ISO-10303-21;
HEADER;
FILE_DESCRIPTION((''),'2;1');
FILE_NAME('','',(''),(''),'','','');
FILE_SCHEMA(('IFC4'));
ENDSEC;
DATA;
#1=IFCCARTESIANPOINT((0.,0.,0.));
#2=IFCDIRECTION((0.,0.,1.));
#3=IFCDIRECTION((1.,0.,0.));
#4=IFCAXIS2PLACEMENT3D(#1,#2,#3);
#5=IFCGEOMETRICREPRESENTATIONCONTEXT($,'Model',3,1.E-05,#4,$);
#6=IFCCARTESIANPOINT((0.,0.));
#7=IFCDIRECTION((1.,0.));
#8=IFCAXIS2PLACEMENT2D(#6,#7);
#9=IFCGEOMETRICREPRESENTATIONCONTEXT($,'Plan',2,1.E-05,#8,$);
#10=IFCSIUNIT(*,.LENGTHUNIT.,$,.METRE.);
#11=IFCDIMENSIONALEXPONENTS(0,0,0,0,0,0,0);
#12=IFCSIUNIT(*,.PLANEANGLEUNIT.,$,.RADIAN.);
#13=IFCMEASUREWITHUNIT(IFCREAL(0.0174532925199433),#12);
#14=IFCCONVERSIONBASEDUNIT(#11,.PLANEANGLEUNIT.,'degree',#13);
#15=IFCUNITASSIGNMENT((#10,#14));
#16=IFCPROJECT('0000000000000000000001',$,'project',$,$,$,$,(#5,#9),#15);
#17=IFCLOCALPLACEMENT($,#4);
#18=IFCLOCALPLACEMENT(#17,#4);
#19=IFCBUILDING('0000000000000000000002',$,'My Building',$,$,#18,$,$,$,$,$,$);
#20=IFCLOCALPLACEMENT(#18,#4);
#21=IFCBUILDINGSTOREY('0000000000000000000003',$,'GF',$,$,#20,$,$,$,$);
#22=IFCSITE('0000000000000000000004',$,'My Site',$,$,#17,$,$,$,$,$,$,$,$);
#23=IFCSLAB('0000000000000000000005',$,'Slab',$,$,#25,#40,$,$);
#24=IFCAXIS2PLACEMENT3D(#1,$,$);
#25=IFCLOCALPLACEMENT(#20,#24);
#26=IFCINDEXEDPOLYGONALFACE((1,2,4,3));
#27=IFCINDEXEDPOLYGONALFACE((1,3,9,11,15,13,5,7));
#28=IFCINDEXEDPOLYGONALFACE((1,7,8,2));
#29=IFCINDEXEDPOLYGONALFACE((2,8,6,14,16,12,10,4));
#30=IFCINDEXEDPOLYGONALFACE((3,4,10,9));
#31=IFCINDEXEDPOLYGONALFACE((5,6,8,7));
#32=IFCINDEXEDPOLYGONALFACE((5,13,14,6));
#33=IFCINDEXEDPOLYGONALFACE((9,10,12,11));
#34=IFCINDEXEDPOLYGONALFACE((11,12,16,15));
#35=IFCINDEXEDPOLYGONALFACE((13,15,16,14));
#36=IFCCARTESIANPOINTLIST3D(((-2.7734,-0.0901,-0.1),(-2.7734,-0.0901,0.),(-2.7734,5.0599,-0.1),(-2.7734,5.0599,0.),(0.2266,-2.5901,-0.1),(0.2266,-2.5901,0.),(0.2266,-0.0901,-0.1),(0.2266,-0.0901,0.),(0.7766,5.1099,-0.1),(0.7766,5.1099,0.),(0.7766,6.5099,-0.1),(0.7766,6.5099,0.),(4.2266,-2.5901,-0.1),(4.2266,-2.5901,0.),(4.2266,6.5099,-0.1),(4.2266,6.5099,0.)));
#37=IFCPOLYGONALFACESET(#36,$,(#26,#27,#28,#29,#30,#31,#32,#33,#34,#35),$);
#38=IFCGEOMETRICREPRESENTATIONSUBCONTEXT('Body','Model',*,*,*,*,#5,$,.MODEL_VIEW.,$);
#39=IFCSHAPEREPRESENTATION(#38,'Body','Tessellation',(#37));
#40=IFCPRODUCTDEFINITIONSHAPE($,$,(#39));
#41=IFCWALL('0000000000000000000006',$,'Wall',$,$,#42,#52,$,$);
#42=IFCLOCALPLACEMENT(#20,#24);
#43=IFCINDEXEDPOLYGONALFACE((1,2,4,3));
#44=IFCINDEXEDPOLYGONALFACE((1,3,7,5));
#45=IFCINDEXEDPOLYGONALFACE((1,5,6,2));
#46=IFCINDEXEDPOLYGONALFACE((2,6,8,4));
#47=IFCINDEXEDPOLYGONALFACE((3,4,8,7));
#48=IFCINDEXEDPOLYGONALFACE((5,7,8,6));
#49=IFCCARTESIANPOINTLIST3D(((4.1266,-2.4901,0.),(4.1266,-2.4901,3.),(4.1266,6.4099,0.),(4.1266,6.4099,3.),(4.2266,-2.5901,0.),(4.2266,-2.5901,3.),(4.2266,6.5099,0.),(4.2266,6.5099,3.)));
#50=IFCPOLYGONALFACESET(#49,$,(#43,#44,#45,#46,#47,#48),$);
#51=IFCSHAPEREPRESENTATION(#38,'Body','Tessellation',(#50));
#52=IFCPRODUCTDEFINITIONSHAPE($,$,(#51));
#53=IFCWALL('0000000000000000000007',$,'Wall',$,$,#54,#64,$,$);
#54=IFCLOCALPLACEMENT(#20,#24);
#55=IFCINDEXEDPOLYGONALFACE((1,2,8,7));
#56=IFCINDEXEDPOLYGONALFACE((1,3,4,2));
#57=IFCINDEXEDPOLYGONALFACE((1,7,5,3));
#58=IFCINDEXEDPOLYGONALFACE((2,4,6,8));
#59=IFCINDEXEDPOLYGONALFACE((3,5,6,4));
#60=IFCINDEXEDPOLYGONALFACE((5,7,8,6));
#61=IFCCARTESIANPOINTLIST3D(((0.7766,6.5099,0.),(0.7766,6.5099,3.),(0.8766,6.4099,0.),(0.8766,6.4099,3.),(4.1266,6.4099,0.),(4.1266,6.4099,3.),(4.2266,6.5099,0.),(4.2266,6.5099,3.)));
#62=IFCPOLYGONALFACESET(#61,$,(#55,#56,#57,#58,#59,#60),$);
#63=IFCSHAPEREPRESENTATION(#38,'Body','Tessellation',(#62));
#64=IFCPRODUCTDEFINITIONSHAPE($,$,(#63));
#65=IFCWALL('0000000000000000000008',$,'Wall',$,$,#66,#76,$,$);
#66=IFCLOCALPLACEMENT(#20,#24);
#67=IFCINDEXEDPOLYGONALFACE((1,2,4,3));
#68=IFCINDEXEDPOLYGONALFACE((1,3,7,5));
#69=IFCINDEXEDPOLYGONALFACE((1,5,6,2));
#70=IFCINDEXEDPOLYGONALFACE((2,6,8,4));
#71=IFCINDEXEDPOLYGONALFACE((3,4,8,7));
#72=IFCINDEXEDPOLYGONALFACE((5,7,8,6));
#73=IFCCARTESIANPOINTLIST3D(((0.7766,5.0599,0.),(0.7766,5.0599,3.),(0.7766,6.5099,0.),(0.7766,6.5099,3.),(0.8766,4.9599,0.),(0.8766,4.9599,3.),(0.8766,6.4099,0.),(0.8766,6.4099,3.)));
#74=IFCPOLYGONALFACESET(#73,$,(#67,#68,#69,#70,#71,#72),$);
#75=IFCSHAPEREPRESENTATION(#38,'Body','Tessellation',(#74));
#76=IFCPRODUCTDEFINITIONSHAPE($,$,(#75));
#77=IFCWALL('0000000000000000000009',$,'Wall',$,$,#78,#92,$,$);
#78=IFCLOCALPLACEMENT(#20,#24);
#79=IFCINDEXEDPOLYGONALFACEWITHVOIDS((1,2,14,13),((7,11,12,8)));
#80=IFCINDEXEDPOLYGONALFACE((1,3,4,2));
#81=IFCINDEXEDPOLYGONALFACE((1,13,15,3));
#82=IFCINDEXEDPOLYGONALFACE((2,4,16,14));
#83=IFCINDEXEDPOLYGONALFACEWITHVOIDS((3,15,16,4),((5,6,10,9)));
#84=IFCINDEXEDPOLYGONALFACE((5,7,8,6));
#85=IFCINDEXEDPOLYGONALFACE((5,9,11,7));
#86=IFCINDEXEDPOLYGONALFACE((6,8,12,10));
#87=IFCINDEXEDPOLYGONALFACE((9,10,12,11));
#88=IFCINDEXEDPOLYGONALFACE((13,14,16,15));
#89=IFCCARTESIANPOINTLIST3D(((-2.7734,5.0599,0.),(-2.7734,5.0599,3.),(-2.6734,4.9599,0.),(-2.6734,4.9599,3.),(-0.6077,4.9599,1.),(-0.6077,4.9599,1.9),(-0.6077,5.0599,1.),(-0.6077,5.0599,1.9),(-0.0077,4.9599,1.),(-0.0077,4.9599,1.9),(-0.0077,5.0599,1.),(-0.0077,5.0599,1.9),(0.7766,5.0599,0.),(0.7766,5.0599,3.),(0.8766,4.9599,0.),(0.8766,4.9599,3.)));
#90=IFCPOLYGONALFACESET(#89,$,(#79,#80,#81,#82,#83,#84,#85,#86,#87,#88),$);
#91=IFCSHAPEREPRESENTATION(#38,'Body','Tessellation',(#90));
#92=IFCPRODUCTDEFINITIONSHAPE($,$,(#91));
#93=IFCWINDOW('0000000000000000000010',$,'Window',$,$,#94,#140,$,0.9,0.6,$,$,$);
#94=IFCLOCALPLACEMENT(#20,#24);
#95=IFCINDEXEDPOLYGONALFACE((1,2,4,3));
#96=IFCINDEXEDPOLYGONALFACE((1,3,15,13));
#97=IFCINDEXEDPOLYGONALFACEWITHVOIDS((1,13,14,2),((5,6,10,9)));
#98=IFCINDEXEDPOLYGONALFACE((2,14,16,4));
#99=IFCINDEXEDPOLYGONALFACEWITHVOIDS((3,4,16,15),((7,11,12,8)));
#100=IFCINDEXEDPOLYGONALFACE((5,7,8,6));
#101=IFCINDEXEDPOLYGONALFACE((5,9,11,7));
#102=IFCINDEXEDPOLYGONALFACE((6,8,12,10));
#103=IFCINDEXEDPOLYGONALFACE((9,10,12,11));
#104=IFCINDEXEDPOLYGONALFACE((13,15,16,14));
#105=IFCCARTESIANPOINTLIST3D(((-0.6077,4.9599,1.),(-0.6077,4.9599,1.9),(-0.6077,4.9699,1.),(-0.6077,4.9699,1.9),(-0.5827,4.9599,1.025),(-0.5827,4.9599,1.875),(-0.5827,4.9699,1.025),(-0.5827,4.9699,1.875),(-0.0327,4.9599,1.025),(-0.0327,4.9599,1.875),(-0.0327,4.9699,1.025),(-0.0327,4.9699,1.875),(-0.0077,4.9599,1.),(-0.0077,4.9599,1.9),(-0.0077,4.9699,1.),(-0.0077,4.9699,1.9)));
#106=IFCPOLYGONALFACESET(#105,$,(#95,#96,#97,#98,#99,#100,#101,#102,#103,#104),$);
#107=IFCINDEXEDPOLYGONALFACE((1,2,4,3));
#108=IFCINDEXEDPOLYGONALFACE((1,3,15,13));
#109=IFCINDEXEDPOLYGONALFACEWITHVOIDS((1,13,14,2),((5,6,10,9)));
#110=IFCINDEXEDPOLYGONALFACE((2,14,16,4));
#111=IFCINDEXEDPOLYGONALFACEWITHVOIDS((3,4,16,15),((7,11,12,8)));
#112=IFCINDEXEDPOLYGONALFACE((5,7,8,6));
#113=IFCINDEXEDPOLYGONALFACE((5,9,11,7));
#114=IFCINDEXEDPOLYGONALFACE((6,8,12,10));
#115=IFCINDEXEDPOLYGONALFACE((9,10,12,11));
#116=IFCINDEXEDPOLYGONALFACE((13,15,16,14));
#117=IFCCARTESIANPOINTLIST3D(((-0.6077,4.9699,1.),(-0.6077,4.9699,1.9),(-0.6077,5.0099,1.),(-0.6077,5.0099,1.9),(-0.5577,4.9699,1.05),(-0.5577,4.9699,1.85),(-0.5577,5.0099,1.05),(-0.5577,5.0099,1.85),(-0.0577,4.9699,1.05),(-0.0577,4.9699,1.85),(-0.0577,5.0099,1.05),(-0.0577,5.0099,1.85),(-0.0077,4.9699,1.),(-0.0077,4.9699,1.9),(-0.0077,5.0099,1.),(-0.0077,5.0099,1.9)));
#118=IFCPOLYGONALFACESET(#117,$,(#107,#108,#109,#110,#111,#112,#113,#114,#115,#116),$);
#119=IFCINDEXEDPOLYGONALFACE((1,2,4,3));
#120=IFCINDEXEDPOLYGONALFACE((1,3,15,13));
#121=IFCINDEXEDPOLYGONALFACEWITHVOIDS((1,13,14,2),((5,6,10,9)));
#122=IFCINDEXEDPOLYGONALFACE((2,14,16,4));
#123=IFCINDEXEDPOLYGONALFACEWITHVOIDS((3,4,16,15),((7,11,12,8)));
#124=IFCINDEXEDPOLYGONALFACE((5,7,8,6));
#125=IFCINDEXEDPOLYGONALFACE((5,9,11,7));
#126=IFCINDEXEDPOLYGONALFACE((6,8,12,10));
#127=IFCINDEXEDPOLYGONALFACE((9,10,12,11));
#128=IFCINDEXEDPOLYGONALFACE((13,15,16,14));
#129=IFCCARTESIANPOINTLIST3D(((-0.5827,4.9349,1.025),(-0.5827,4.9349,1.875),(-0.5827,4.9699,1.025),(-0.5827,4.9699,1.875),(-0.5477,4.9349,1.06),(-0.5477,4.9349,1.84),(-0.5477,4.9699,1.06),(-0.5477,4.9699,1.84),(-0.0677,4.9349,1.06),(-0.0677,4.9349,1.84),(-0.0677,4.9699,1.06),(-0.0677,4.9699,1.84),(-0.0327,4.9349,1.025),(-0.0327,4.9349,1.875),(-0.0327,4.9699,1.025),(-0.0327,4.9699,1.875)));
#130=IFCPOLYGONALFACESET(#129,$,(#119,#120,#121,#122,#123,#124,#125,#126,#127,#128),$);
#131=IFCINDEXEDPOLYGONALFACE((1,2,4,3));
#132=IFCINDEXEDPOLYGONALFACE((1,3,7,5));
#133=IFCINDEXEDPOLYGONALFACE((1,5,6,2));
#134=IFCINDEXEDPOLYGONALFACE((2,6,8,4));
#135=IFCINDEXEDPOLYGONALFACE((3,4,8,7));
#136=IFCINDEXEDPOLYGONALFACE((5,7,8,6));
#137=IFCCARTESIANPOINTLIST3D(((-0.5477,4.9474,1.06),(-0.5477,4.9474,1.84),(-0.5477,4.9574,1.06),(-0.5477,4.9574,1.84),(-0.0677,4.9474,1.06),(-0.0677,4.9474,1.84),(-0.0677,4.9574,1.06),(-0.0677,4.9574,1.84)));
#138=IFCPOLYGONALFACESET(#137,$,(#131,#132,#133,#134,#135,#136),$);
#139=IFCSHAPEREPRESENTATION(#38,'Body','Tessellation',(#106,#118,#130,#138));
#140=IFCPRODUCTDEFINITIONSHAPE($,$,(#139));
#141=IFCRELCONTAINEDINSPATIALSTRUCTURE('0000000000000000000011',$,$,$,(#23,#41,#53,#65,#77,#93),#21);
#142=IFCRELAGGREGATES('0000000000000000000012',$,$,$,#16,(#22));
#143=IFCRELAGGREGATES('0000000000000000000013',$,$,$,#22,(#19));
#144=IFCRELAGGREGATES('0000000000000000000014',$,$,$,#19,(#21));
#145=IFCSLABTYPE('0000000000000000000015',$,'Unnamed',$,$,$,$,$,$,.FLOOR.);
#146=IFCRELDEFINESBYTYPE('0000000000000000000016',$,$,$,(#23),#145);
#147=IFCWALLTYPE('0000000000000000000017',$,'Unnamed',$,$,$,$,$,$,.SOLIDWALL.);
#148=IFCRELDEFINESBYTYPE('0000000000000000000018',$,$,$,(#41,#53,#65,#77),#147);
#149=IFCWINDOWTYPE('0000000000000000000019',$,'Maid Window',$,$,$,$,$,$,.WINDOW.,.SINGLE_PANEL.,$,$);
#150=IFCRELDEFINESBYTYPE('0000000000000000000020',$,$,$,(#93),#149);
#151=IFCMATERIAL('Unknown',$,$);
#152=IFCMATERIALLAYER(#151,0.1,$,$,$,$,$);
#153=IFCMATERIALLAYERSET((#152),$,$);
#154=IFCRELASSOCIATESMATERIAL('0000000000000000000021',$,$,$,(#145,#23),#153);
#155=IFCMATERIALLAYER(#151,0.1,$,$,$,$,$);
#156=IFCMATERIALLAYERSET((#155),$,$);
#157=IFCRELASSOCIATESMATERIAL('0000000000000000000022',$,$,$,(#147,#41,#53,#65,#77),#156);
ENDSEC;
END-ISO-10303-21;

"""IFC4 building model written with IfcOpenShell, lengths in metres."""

from ifc_helpers import new_model, entity, si_unit, converted_unit, frame, origin_with_axes, origin_2d_with_axis, place, context, subcontext, project, spatial, line, indexed_curve, outline, extrude, shape, source, transform, mapped, material, layer, layer_set, layer_usage, type_object, type_shapes, element, fill, save


model = new_model("IFC4")

# Units and contexts
model_context = context("Model", 3, precision=1e-05, world=origin_with_axes())
plan_context = context("Plan", 2, precision=1e-05, world=origin_2d_with_axis())
body_context_1 = subcontext(model_context, "Body", "Model", "MODEL_VIEW")
body_context_2 = subcontext(plan_context, "Body", "Plan", "PLAN_VIEW")
ifc_project = project(units=[si_unit("LENGTHUNIT", "METRE"), converted_unit("PLANEANGLEUNIT", "degree", entity("IfcReal", 0.0174532925199433), si_unit("PLANEANGLEUNIT", "RADIAN"), dimensions=[0, 0, 0, 0, 0, 0, 0])], contexts=[model_context, plan_context])

# Site, building, storey
site_placement = place(None, origin_with_axes())
site = spatial("IfcSite", under=ifc_project, at=site_placement, Name="My Site")
building_placement = place(site_placement, origin_with_axes())
building = spatial("IfcBuilding", under=site, at=building_placement, Name="My Building")
storey_placement = place(building_placement, origin_with_axes())
storey = spatial("IfcBuildingStorey", under=building, at=storey_placement, Name="GF")

# Slab
ifc_material = material(Name="Unknown")
ifc_layer_1 = layer(ifc_material, 0.1)
ifc_layer_set_1 = layer_set([ifc_layer_1])
ifc_layer_usage_1 = layer_usage(ifc_layer_set_1, "AXIS3", "POSITIVE", -0.1)
slab_type = type_object("IfcSlabType", Name="Unnamed", PredefinedType="FLOOR", material=ifc_layer_set_1)
slab_placement = place(storey_placement, frame((4.2266, 6.5099, 0.0), z_axis=(0.0, 0.0, 1.0), x_axis=(1.0, 0.0, 0.0)))
element("IfcSlab", 1, at=slab_placement, inside=storey, type_object=slab_type, material=ifc_layer_usage_1, Name="Slab", context=body_context_1, shape_type="SweptSolid", body=[
    extrude(outline(indexed_curve([(0.0, 0.0), (-3.45, 0.0), (-3.45, -1.4), (-7.0, -1.45), (-7.0, -6.6), (-4.0, -6.6), (-4.0, -9.1), (0.0, -9.1), (0.0, 0.0)])), frame((0.0, 0.0, -0.1), z_axis=(0.0, 0.0, 1.0), x_axis=(1.0, 0.0, 0.0)), (0.0, 0.0, 1.0), 0.1),
])

# Shared definitions
ifc_layer_2 = layer(ifc_material, 0.1)
ifc_layer_set_2 = layer_set([ifc_layer_2])
wall_type = type_object("IfcWallType", Name="Unnamed", PredefinedType="SOLIDWALL", material=ifc_layer_set_2)

# Walls
ifc_layer_usage_2 = layer_usage(ifc_layer_set_2, "AXIS2", "POSITIVE", 0.0)
wall_1_placement = place(storey_placement, frame((4.2266, -2.5901, 0.0), z_axis=(0.0, 0.0, 1.0), x_axis=(0.0, 1.0, 0.0)))
element("IfcWall", 2, at=wall_1_placement, inside=storey, type_object=wall_type, material=ifc_layer_usage_2, Name="Wall", context=body_context_1, shape_type="SweptSolid", body=[
    extrude(outline(indexed_curve([(0.0, 0.0), (0.1, 0.1), (9.0, 0.1), (9.1, 0.0)], segments=[line(1, 2, 3, 4, 1)])), origin_with_axes(), (0.0, 0.0, 1.0), 3.0),
])
ifc_layer_usage_3 = layer_usage(ifc_layer_set_2, "AXIS2", "POSITIVE", 0.0)
wall_2_placement = place(storey_placement, frame((4.2266, 6.5099, 0.0), z_axis=(0.0, 0.0, 1.0), x_axis=(-1.0, 0.0, 0.0)))
element("IfcWall", 3, at=wall_2_placement, inside=storey, type_object=wall_type, material=ifc_layer_usage_3, Name="Wall", context=body_context_1, shape_type="SweptSolid", body=[
    extrude(outline(indexed_curve([(0.0, 0.0), (0.1, 0.1), (3.35, 0.1), (3.45, 0.0)], segments=[line(1, 2, 3, 4, 1)])), origin_with_axes(), (0.0, 0.0, 1.0), 3.0),
])
ifc_layer_usage_4 = layer_usage(ifc_layer_set_2, "AXIS2", "POSITIVE", 0.0)
wall_3_placement = place(storey_placement, frame((0.7766, 6.5099, 0.0), z_axis=(0.0, 0.0, 1.0), x_axis=(0.0, -1.0, 0.0)))
element("IfcWall", 4, at=wall_3_placement, inside=storey, type_object=wall_type, material=ifc_layer_usage_4, Name="Wall", context=body_context_1, shape_type="SweptSolid", body=[
    extrude(outline(indexed_curve([(0.0, 0.0), (0.1, 0.1), (1.55, 0.1), (1.45, 0.0)], segments=[line(1, 2, 3, 4, 1)])), origin_with_axes(), (0.0, 0.0, 1.0), 3.0),
])

# Wall, opening, window
ifc_layer_usage_5 = layer_usage(ifc_layer_set_2, "AXIS2", "POSITIVE", 0.0)
wall_4_placement = place(storey_placement, frame((0.7766, 5.0599, 0.0), z_axis=(0.0, 0.0, 1.0), x_axis=(-1.0, 0.0, 0.0)))
wall_4 = element("IfcWall", 5, at=wall_4_placement, inside=storey, type_object=wall_type, material=ifc_layer_usage_5, Name="Wall", context=body_context_1, shape_type="SweptSolid", body=[
    extrude(outline(indexed_curve([(0.0, 0.0), (-0.1, 0.1), (3.45, 0.1), (3.55, 0.0)], segments=[line(1, 2, 3, 4, 1)])), origin_with_axes(), (0.0, 0.0, 1.0), 3.0),
])
shared_shape_1 = source(origin_with_axes(), body_context_1, "Body", "SweptSolid", [
    extrude(outline(indexed_curve([(0.0, 0.0), (0.6, 0.0), (0.6, 0.9), (0.0, 0.9)], segments=[line(1, 2, 3, 4, 1)])), frame((0.0, -0.6, 0.0), z_axis=(0.0, -1.0, 0.0), x_axis=(1.0, 0.0, 0.0)), (0.0, 0.0, -1.0), 1.2),
])
opening_1_placement = place(wall_4_placement, frame((0.7843, 0.0, 1.0), z_axis=(0.0, 0.0, 1.0), x_axis=(1.0, 0.0, 0.0)))
opening_1 = element("IfcOpeningElement", 6, at=opening_1_placement, cuts=wall_4, PredefinedType="OPENING", context=body_context_1, shape_type="MappedRepresentation", body=[
    mapped(shared_shape_1, transform((0.0, 0.0, 0.0), x_axis=(1.0, 0.0, 0.0), y_axis=(0.0, 1.0, 0.0), z_axis=(0.0, 0.0, 1.0), scale=1.0)),
])
window_type_1 = type_object("IfcWindowType", Name="Maid Window", PartitioningType="SINGLE_PANEL", PredefinedType="WINDOW")
shared_shape_2 = source(origin_with_axes(), body_context_1, "Body", "SweptSolid", [
    extrude(outline(indexed_curve([(0.0, 0.0), (0.6, 0.0), (0.6, 0.9), (0.0, 0.9)], segments=[line(1, 2, 3, 4, 1)]), holes=[indexed_curve([(0.025, 0.025), (0.575, 0.025), (0.575, 0.875), (0.025, 0.875)], segments=[line(1, 2, 3, 4, 1)])]), frame((0.0, 0.09, 0.0), z_axis=(0.0, -1.0, 0.0), x_axis=(1.0, 0.0, 0.0)), (0.0, 0.0, -1.0), 0.01),
    extrude(outline(indexed_curve([(0.0, 0.0), (0.6, 0.0), (0.6, 0.9), (0.0, 0.9)], segments=[line(1, 2, 3, 4, 1)]), holes=[indexed_curve([(0.05, 0.05), (0.55, 0.05), (0.55, 0.85), (0.05, 0.85)], segments=[line(1, 2, 3, 4, 1)])]), frame((0.0, 0.05, 0.0), z_axis=(0.0, -1.0, 0.0), x_axis=(1.0, 0.0, 0.0)), (0.0, 0.0, -1.0), 0.04),
    extrude(outline(indexed_curve([(0.0, 0.0), (0.55, 0.0), (0.55, 0.85), (0.0, 0.85)], segments=[line(1, 2, 3, 4, 1)]), holes=[indexed_curve([(0.035, 0.035), (0.515, 0.035), (0.515, 0.815), (0.035, 0.815)], segments=[line(1, 2, 3, 4, 1)])]), frame((0.025, 0.09, 0.025), z_axis=(0.0, -1.0, 0.0), x_axis=(1.0, 0.0, 0.0)), (0.0, 0.0, -1.0), 0.035),
    extrude(outline(indexed_curve([(0.035, 0.035), (0.515, 0.035), (0.515, 0.815), (0.035, 0.815)], segments=[line(1, 2, 3, 4, 1)])), frame((0.025, 0.1025, 0.025), z_axis=(0.0, -1.0, 0.0), x_axis=(1.0, 0.0, 0.0)), (0.0, 0.0, -1.0), 0.01),
])
shared_shape_3 = source(origin_with_axes(), body_context_2, "Body", "Curve2D", [
    entity("IfcIndexedPolyCurve", entity("IfcCartesianPointList2D", [[0.05, 0.05], [0.55, 0.05]])),
    entity("IfcIndexedPolyCurve", entity("IfcCartesianPointList2D", [[0.0, 0.1], [0.025, 0.1], [0.025, 0.09], [0.05, 0.09], [0.05, 0.05], [0.0, 0.05]]), [entity("IfcLineIndex", [1, 2, 3, 4, 5, 6, 1])]),
    entity("IfcIndexedPolyCurve", entity("IfcCartesianPointList2D", [[0.6, 0.1], [0.575, 0.1], [0.575, 0.09], [0.55, 0.09], [0.55, 0.05], [0.6, 0.05]]), [entity("IfcLineIndex", [1, 2, 3, 4, 5, 6, 1])]),
    entity("IfcIndexedPolyCurve", entity("IfcCartesianPointList2D", [[0.025, 0.09], [0.06, 0.09], [0.06, 0.125], [0.025, 0.125]]), [entity("IfcLineIndex", [1, 2, 3, 4, 1])]),
    entity("IfcIndexedPolyCurve", entity("IfcCartesianPointList2D", [[0.575, 0.09], [0.54, 0.09], [0.54, 0.125], [0.575, 0.125]]), [entity("IfcLineIndex", [1, 2, 3, 4, 1])]),
    entity("IfcIndexedPolyCurve", entity("IfcCartesianPointList2D", [[0.06, 0.09], [0.54, 0.09]])),
    entity("IfcIndexedPolyCurve", entity("IfcCartesianPointList2D", [[0.06, 0.125], [0.54, 0.125]])),
    entity("IfcIndexedPolyCurve", entity("IfcCartesianPointList2D", [[0.06, 0.1075], [0.54, 0.1075]])),
])
type_shapes(window_type_1, [shared_shape_2, shared_shape_3])
window_1_placement = place(opening_1_placement, frame((0.0, 0.0, 0.0), z_axis=(0.0, 0.0, 1.0), x_axis=(1.0, 0.0, 0.0)))
window_1 = element("IfcWindow", 7, at=window_1_placement, inside=storey, type_object=window_type_1, Name="Window", OverallHeight=0.9, OverallWidth=0.6, shapes=[
    shape(body_context_1, "Body", "MappedRepresentation", [mapped(shared_shape_2, transform((0.0, 0.0, 0.0), x_axis=(1.0, 0.0, 0.0), y_axis=(0.0, 1.0, 0.0), z_axis=(0.0, 0.0, 1.0), scale=1.0))]),
    shape(body_context_2, "Body", "MappedRepresentation", [mapped(shared_shape_3, transform((0.0, 0.0, 0.0), x_axis=(1.0, 0.0, 0.0), y_axis=(0.0, 1.0, 0.0), z_axis=(0.0, 0.0, 1.0), scale=1.0))]),
])
fill(opening_1, window_1)

save(model, "model.ifc")
